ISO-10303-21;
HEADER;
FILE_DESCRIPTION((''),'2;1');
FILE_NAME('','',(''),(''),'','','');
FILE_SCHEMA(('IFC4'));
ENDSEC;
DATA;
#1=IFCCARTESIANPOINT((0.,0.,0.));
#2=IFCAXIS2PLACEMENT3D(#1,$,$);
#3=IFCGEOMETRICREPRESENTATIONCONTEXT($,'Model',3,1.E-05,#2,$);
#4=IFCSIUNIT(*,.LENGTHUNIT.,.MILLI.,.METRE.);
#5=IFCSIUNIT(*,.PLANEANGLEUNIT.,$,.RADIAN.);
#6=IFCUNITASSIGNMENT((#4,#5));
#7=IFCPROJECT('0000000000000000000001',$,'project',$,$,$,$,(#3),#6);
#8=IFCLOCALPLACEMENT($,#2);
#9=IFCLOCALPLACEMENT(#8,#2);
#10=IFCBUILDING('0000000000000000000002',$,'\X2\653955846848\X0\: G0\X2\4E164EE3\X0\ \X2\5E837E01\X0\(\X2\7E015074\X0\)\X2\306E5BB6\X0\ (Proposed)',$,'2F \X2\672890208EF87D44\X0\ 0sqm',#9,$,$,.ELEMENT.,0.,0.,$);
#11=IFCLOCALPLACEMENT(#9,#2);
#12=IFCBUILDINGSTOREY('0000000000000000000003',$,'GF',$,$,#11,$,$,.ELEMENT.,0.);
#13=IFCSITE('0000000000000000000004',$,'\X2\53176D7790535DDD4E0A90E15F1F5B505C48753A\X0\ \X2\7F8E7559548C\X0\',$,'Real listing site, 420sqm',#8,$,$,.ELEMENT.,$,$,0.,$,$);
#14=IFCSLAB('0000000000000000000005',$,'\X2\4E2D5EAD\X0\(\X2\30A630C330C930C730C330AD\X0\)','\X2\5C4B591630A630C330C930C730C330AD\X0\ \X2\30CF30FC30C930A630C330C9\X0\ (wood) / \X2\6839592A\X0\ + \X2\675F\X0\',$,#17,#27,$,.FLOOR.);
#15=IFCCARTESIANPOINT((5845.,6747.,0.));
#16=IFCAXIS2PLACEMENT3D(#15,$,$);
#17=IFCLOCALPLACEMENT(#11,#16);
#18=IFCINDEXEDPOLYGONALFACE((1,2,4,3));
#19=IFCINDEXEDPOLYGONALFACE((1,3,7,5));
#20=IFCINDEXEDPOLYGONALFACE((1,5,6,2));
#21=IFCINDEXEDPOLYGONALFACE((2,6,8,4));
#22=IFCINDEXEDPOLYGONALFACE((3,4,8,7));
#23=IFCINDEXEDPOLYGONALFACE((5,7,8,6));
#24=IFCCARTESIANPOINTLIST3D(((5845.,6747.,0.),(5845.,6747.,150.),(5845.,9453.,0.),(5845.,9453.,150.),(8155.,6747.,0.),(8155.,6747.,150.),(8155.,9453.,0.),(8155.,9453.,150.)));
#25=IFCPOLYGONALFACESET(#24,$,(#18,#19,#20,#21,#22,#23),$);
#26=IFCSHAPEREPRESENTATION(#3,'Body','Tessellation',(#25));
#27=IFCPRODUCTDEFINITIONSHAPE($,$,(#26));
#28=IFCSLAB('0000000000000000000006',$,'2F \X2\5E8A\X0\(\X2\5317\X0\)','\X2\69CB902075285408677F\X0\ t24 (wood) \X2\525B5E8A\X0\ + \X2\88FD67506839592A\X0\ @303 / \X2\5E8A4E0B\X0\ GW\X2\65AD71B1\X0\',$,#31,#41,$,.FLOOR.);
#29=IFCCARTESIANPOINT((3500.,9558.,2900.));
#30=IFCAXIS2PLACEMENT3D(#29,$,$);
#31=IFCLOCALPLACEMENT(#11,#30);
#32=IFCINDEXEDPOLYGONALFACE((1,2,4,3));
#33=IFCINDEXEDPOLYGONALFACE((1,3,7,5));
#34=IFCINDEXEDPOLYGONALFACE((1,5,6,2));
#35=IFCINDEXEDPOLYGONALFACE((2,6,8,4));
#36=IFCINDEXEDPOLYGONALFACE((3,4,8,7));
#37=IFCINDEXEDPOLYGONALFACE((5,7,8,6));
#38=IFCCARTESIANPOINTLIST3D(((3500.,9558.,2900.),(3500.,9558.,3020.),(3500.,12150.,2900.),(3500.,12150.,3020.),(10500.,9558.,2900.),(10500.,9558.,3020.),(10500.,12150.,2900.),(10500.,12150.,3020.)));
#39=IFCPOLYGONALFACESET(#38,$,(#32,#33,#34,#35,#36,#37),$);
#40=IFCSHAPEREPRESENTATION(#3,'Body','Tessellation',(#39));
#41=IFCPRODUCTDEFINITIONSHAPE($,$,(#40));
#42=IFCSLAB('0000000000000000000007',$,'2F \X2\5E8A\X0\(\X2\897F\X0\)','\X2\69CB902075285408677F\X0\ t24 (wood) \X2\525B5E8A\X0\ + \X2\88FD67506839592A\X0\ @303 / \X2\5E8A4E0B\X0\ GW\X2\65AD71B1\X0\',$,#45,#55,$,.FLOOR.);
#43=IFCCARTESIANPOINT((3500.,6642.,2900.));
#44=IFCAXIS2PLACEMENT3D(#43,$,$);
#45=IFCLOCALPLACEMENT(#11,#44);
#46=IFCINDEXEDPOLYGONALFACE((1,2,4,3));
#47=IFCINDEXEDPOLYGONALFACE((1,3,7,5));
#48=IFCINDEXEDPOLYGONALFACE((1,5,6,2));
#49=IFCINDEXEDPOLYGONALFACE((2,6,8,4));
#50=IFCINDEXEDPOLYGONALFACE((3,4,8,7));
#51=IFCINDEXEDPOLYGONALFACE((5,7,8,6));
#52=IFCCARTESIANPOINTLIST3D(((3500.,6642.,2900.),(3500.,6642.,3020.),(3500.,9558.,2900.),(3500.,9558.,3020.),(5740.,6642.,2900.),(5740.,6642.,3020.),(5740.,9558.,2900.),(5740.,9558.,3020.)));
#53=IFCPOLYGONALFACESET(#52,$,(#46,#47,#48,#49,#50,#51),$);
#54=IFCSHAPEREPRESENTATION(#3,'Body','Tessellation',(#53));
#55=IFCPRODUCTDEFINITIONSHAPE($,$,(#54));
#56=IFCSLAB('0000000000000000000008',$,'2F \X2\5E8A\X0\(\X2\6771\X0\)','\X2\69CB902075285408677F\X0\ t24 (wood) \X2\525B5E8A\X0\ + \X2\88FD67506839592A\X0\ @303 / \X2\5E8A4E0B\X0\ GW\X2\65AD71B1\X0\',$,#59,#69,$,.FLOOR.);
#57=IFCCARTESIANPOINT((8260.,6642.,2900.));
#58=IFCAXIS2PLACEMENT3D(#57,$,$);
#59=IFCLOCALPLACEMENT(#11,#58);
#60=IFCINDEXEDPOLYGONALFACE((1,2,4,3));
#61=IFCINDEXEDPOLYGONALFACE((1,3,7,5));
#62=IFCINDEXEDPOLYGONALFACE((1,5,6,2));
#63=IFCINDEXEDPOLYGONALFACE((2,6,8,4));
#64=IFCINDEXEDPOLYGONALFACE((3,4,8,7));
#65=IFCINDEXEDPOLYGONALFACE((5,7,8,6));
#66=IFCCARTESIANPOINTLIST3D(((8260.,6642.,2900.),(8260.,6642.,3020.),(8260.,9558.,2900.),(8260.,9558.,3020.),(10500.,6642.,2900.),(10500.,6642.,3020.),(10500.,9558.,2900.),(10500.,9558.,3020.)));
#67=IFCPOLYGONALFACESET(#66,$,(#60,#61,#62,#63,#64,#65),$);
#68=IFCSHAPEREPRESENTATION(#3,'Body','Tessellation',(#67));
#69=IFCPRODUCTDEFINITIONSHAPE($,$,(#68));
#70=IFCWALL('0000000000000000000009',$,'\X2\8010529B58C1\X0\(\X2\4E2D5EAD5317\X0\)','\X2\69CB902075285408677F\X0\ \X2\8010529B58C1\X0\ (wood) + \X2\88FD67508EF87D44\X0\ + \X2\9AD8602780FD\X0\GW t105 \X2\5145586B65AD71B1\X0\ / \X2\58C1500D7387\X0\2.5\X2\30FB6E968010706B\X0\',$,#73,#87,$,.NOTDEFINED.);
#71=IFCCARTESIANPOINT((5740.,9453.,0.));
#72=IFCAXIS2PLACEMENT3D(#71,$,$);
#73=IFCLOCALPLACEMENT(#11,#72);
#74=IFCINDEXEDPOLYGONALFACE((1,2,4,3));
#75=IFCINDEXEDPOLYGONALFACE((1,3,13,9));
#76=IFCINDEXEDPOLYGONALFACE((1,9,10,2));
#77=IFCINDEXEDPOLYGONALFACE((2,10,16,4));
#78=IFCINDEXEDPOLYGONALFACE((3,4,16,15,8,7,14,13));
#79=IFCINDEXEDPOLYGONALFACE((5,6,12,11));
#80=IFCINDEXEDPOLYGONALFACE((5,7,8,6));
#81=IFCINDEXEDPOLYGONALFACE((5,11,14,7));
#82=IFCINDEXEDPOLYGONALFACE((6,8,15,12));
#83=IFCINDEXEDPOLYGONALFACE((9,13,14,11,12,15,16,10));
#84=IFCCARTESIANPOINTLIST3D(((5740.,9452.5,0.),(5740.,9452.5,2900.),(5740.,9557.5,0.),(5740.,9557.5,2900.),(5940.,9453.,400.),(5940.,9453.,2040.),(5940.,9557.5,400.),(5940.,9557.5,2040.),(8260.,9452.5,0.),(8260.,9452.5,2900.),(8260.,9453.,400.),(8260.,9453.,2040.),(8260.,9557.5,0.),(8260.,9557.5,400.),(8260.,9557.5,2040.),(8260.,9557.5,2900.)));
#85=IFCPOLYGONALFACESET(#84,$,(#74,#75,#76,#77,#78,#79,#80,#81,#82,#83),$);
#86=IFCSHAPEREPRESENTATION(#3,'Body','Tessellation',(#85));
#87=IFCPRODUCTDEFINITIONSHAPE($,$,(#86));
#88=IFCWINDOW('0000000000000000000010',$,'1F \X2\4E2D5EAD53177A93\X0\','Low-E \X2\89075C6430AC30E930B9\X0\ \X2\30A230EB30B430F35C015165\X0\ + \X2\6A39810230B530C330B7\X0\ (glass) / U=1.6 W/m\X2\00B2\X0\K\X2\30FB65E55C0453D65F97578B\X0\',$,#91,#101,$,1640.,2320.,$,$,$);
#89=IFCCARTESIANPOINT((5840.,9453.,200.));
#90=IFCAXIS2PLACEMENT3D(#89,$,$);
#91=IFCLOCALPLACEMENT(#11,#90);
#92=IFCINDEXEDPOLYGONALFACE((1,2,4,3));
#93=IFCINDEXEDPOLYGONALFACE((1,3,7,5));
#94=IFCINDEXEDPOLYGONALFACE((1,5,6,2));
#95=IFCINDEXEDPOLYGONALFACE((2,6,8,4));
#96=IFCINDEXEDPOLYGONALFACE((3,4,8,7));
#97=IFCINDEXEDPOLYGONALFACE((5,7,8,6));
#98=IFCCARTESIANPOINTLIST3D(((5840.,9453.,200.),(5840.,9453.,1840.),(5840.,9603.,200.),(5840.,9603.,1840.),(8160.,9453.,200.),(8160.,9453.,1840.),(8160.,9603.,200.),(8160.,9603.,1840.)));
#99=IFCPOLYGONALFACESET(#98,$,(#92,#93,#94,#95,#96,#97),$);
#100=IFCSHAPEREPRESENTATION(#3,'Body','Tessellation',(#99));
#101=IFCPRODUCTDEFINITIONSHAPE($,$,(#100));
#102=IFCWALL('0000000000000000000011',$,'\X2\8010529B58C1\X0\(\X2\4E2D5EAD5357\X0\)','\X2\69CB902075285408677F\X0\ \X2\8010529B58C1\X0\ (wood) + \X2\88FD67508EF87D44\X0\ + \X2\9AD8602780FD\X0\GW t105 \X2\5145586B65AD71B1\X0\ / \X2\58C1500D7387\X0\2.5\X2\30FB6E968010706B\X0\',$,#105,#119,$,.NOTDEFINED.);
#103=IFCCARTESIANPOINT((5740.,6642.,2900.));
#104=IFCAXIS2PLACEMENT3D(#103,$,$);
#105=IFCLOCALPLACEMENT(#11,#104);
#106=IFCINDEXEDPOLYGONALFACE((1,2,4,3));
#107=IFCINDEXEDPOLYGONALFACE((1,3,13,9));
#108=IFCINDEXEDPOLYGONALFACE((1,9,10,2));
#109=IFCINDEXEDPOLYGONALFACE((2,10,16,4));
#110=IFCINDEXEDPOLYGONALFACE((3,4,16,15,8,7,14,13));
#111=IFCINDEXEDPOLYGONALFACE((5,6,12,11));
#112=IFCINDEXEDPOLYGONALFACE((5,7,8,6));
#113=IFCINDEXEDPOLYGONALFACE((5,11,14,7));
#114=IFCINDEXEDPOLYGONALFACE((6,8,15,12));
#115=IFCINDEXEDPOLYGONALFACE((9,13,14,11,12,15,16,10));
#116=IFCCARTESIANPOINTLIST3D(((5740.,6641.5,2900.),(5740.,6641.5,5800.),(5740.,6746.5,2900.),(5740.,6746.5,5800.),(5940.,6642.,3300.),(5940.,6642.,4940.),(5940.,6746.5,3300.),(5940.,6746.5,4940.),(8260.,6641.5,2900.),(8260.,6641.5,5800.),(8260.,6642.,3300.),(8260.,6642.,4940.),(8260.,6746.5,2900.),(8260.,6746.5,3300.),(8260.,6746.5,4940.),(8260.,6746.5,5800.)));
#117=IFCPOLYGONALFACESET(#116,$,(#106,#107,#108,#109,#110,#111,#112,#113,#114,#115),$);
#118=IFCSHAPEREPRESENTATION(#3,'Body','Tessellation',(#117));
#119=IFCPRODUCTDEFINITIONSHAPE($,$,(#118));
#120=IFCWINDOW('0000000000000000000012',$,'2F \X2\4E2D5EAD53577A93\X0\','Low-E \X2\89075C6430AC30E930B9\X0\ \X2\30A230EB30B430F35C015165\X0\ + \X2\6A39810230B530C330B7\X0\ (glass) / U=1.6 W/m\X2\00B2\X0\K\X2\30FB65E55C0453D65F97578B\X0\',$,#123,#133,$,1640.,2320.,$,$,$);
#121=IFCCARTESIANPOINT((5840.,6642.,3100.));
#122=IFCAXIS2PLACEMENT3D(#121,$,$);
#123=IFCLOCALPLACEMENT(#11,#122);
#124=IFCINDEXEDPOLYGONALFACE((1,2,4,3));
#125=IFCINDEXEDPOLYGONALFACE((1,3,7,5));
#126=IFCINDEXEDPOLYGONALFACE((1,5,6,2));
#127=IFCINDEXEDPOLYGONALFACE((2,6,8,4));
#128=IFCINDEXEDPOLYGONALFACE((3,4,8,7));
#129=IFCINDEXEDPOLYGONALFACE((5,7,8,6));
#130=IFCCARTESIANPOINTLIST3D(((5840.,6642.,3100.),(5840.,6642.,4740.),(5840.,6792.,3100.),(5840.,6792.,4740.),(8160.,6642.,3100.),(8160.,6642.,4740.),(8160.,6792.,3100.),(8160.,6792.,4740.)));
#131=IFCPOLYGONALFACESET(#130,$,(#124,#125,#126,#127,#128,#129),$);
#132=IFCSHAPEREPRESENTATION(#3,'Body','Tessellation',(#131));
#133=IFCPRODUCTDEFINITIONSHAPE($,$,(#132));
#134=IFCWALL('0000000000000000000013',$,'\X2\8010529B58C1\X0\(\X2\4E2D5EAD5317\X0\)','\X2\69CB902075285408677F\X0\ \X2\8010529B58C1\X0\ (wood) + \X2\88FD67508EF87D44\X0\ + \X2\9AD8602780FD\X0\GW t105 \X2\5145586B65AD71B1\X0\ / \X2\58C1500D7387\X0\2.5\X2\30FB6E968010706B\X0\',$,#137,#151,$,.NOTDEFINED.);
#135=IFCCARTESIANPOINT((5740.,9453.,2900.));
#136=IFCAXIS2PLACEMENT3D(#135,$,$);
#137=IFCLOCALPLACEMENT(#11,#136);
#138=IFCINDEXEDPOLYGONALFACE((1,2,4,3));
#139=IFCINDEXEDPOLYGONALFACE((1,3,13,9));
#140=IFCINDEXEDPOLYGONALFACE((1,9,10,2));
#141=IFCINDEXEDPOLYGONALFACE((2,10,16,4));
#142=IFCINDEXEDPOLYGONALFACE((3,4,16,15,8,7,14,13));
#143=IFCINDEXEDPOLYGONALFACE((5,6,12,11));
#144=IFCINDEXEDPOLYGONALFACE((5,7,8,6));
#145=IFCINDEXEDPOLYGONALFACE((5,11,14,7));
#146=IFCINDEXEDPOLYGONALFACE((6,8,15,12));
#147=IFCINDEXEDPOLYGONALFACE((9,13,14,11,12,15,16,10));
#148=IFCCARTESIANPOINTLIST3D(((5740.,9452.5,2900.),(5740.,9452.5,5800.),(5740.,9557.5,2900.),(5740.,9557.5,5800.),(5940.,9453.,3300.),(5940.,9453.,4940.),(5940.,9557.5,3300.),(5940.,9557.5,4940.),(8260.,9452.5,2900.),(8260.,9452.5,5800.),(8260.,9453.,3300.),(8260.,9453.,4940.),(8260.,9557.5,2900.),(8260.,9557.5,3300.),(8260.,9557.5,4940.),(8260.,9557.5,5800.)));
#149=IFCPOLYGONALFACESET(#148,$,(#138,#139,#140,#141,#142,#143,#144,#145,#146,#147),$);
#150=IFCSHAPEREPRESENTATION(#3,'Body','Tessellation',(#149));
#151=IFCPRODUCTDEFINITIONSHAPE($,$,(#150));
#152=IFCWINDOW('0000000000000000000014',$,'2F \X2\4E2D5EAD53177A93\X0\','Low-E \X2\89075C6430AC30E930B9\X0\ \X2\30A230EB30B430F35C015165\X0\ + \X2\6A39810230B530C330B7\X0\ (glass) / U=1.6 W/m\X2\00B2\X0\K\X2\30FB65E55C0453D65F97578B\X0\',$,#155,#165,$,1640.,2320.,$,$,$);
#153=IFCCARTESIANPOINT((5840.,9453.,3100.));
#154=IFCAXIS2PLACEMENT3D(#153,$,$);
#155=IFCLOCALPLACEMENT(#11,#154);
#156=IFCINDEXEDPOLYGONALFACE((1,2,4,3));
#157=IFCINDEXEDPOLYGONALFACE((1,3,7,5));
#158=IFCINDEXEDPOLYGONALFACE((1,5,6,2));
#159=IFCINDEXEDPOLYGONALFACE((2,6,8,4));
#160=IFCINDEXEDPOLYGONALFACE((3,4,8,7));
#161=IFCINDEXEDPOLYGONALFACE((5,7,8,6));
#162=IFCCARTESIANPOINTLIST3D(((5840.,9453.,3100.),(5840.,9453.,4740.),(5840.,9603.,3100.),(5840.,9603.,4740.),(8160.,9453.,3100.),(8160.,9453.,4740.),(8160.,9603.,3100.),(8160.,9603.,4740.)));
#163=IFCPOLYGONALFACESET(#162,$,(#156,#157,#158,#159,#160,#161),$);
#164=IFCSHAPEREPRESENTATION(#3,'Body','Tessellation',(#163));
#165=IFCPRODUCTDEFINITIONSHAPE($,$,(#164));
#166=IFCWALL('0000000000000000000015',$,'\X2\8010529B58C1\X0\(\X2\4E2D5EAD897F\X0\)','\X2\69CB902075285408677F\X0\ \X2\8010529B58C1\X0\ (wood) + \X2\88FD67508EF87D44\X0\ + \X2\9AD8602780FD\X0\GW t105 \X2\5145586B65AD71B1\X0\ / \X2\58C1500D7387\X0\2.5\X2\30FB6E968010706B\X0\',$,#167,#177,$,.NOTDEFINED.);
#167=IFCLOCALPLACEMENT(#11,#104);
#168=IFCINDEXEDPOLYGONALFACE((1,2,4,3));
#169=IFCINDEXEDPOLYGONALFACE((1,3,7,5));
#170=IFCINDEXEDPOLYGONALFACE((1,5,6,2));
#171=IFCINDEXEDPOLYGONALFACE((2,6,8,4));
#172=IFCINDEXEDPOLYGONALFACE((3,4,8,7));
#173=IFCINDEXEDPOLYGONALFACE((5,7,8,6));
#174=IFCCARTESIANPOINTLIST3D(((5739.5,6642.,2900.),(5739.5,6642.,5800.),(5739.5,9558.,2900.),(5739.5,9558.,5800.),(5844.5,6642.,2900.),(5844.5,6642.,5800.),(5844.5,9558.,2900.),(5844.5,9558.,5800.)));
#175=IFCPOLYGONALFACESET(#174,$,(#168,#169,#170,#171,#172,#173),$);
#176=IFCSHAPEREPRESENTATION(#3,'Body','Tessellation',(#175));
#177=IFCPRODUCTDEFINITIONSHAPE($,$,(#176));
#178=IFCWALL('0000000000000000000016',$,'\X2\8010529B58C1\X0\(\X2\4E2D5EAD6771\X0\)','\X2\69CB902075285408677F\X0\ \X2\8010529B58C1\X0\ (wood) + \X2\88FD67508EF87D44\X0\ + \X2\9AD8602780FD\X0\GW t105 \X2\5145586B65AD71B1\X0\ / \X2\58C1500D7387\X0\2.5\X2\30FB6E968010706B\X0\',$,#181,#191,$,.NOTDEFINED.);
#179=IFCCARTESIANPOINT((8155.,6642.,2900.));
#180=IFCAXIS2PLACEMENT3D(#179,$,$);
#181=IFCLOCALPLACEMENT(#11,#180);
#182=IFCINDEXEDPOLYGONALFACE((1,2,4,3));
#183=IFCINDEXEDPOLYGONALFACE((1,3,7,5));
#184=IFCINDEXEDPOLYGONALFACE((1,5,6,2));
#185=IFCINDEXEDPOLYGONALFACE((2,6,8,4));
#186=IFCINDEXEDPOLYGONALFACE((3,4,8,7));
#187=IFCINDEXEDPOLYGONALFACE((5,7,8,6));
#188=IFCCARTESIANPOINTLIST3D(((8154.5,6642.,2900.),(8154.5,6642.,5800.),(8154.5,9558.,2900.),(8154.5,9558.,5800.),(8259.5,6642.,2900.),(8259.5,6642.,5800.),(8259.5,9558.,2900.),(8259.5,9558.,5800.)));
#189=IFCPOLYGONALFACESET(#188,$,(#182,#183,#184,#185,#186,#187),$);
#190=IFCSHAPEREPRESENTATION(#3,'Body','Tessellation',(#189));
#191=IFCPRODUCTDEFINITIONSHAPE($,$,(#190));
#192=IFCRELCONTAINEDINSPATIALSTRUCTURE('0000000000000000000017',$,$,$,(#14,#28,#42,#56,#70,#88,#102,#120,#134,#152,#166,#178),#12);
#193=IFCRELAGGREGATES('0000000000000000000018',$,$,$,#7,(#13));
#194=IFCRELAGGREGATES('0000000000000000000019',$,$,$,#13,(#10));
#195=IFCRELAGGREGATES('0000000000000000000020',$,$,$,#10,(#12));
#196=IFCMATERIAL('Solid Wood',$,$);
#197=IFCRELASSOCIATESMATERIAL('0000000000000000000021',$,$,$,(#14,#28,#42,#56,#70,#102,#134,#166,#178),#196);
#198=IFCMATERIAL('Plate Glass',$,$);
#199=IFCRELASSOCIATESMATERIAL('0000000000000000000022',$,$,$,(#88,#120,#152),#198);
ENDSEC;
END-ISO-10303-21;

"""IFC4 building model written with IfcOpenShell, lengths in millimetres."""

from ifc_helpers import new_model, si_unit, frame, frame_2d, origin, place, context, project, spatial, rectangle, extrude, material, element, fill, save


model = new_model("IFC4")

# Units and contexts
model_context = context("Model", 3, precision=1e-05, world=origin())
ifc_project = project(units=[si_unit("LENGTHUNIT", "METRE", prefix="MILLI"), si_unit("PLANEANGLEUNIT", "RADIAN")], contexts=[model_context])

# Site, building, storey
site_placement = place(None, origin())
site = spatial("IfcSite", under=ifc_project, at=site_placement, Name="北海道川上郡弟子屈町 美留和", ObjectType="Real listing site, 420sqm", CompositionType="ELEMENT", RefElevation=0.0)
building_placement = place(site_placement, origin())
building = spatial("IfcBuilding", under=site, at=building_placement, Name="改善案: G0世代 広縁(縁側)の家 (Proposed)", ObjectType="2F 木造軸組 0sqm", CompositionType="ELEMENT", ElevationOfRefHeight=0.0, ElevationOfTerrain=0.0)
storey_placement = place(building_placement, origin())
storey = spatial("IfcBuildingStorey", under=building, at=storey_placement, Name="GF", CompositionType="ELEMENT", Elevation=0.0)

# Slabs
ifc_material_1 = material(Name="Solid Wood")
slab_1_placement = place(storey_placement, frame((5845.0, 6747.0, 0.0)))
element("IfcSlab", 1, at=slab_1_placement, inside=storey, material=ifc_material_1, Name="中庭(ウッドデッキ)", Description="屋外ウッドデッキ ハードウッド (wood) / 根太 + 束", PredefinedType="FLOOR", context=model_context, shape_type="SweptSolid", body=[
    extrude(rectangle(XDim=2310.0, YDim=2706.0, at=frame_2d((1155.0, 1353.0))), frame((5845.0, 6747.0, 0.0)), (0.0, 0.0, 1.0), 150.0),
])
slab_2_placement = place(storey_placement, frame((3500.0, 9558.0, 2900.0)))
element("IfcSlab", 2, at=slab_2_placement, inside=storey, material=ifc_material_1, Name="2F 床(北)", Description="構造用合板 t24 (wood) 剛床 + 製材根太 @303 / 床下 GW断熱", PredefinedType="FLOOR", context=model_context, shape_type="SweptSolid", body=[
    extrude(rectangle(XDim=7000.0, YDim=2592.0, at=frame_2d((3500.0, 1296.0))), frame((3500.0, 9558.0, 2900.0)), (0.0, 0.0, 1.0), 120.0),
])
slab_3_placement = place(storey_placement, frame((3500.0, 6642.0, 2900.0)))
element("IfcSlab", 3, at=slab_3_placement, inside=storey, material=ifc_material_1, Name="2F 床(西)", Description="構造用合板 t24 (wood) 剛床 + 製材根太 @303 / 床下 GW断熱", PredefinedType="FLOOR", context=model_context, shape_type="SweptSolid", body=[
    extrude(rectangle(XDim=2240.0, YDim=2916.0, at=frame_2d((1120.0, 1458.0))), frame((3500.0, 6642.0, 2900.0)), (0.0, 0.0, 1.0), 120.0),
])
slab_4_placement = place(storey_placement, frame((8260.0, 6642.0, 2900.0)))
element("IfcSlab", 4, at=slab_4_placement, inside=storey, material=ifc_material_1, Name="2F 床(東)", Description="構造用合板 t24 (wood) 剛床 + 製材根太 @303 / 床下 GW断熱", PredefinedType="FLOOR", context=model_context, shape_type="SweptSolid", body=[
    extrude(rectangle(XDim=2240.0, YDim=2916.0, at=frame_2d((1120.0, 1458.0))), frame((8260.0, 6642.0, 2900.0)), (0.0, 0.0, 1.0), 120.0),
])

# Wall, opening, window
wall_1_placement = place(storey_placement, frame((5740.0, 9453.0, 0.0)))
wall_1 = element("IfcWall", 5, at=wall_1_placement, inside=storey, material=ifc_material_1, Name="耐力壁(中庭北)", Description="構造用合板 耐力壁 (wood) + 製材軸組 + 高性能GW t105 充填断熱 / 壁倍率2.5・準耐火", PredefinedType="NOTDEFINED", context=model_context, shape_type="SweptSolid", body=[
    extrude(rectangle(XDim=2520.0, YDim=105.0, at=frame_2d((1260.0, 52.0))), frame((5740.0, 9453.0, 0.0)), (0.0, 0.0, 1.0), 2900.0),
])
opening_1_placement = place(storey_placement, frame((5840.0, 9453.0, 200.0)))
opening_1 = element("IfcOpeningElement", 6, at=opening_1_placement, cuts=wall_1, PredefinedType="NOTDEFINED", context=model_context, shape_type="SweptSolid", body=[
    extrude(rectangle(XDim=2320.0, YDim=150.0, at=frame_2d((1160.0, 75.0))), frame((5840.0, 9453.0, 200.0)), (0.0, 0.0, 1.0), 1640.0),
])
ifc_material_2 = material(Name="Plate Glass")
window_1_placement = place(storey_placement, frame((5840.0, 9453.0, 200.0)))
window_1 = element("IfcWindow", 7, at=window_1_placement, inside=storey, material=ifc_material_2, Name="1F 中庭北窓", Description="Low-E 複層ガラス アルゴン封入 + 樹脂サッシ (glass) / U=1.6 W/m²K・日射取得型", OverallHeight=1640.0, OverallWidth=2320.0, context=model_context, shape_type="SweptSolid", body=[
    extrude(rectangle(XDim=2320.0, YDim=150.0, at=frame_2d((1160.0, 75.0))), frame((5840.0, 9453.0, 200.0)), (0.0, 0.0, 1.0), 1640.0),
])
fill(opening_1, window_1)

# Walls, openings, windows
wall_2_placement = place(storey_placement, frame((5740.0, 6642.0, 2900.0)))
wall_2 = element("IfcWall", 8, at=wall_2_placement, inside=storey, material=ifc_material_1, Name="耐力壁(中庭南)", Description="構造用合板 耐力壁 (wood) + 製材軸組 + 高性能GW t105 充填断熱 / 壁倍率2.5・準耐火", PredefinedType="NOTDEFINED", context=model_context, shape_type="SweptSolid", body=[
    extrude(rectangle(XDim=2520.0, YDim=105.0, at=frame_2d((1260.0, 52.0))), frame((5740.0, 6642.0, 2900.0)), (0.0, 0.0, 1.0), 2900.0),
])
opening_2_placement = place(storey_placement, frame((5840.0, 6642.0, 3100.0)))
opening_2 = element("IfcOpeningElement", 9, at=opening_2_placement, cuts=wall_2, PredefinedType="NOTDEFINED", context=model_context, shape_type="SweptSolid", body=[
    extrude(rectangle(XDim=2320.0, YDim=150.0, at=frame_2d((1160.0, 75.0))), frame((5840.0, 6642.0, 3100.0)), (0.0, 0.0, 1.0), 1640.0),
])
window_2_placement = place(storey_placement, frame((5840.0, 6642.0, 3100.0)))
window_2 = element("IfcWindow", 10, at=window_2_placement, inside=storey, material=ifc_material_2, Name="2F 中庭南窓", Description="Low-E 複層ガラス アルゴン封入 + 樹脂サッシ (glass) / U=1.6 W/m²K・日射取得型", OverallHeight=1640.0, OverallWidth=2320.0, context=model_context, shape_type="SweptSolid", body=[
    extrude(rectangle(XDim=2320.0, YDim=150.0, at=frame_2d((1160.0, 75.0))), frame((5840.0, 6642.0, 3100.0)), (0.0, 0.0, 1.0), 1640.0),
])
fill(opening_2, window_2)
wall_3_placement = place(storey_placement, frame((5740.0, 9453.0, 2900.0)))
wall_3 = element("IfcWall", 11, at=wall_3_placement, inside=storey, material=ifc_material_1, Name="耐力壁(中庭北)", Description="構造用合板 耐力壁 (wood) + 製材軸組 + 高性能GW t105 充填断熱 / 壁倍率2.5・準耐火", PredefinedType="NOTDEFINED", context=model_context, shape_type="SweptSolid", body=[
    extrude(rectangle(XDim=2520.0, YDim=105.0, at=frame_2d((1260.0, 52.0))), frame((5740.0, 9453.0, 2900.0)), (0.0, 0.0, 1.0), 2900.0),
])
opening_3_placement = place(storey_placement, frame((5840.0, 9453.0, 3100.0)))
opening_3 = element("IfcOpeningElement", 12, at=opening_3_placement, cuts=wall_3, PredefinedType="NOTDEFINED", context=model_context, shape_type="SweptSolid", body=[
    extrude(rectangle(XDim=2320.0, YDim=150.0, at=frame_2d((1160.0, 75.0))), frame((5840.0, 9453.0, 3100.0)), (0.0, 0.0, 1.0), 1640.0),
])
window_3_placement = place(storey_placement, frame((5840.0, 9453.0, 3100.0)))
window_3 = element("IfcWindow", 13, at=window_3_placement, inside=storey, material=ifc_material_2, Name="2F 中庭北窓", Description="Low-E 複層ガラス アルゴン封入 + 樹脂サッシ (glass) / U=1.6 W/m²K・日射取得型", OverallHeight=1640.0, OverallWidth=2320.0, context=model_context, shape_type="SweptSolid", body=[
    extrude(rectangle(XDim=2320.0, YDim=150.0, at=frame_2d((1160.0, 75.0))), frame((5840.0, 9453.0, 3100.0)), (0.0, 0.0, 1.0), 1640.0),
])
fill(opening_3, window_3)

# Walls
wall_4_placement = place(storey_placement, frame((5740.0, 6642.0, 2900.0)))
element("IfcWall", 14, at=wall_4_placement, inside=storey, material=ifc_material_1, Name="耐力壁(中庭西)", Description="構造用合板 耐力壁 (wood) + 製材軸組 + 高性能GW t105 充填断熱 / 壁倍率2.5・準耐火", PredefinedType="NOTDEFINED", context=model_context, shape_type="SweptSolid", body=[
    extrude(rectangle(XDim=105.0, YDim=2916.0, at=frame_2d((52.0, 1458.0))), frame((5740.0, 6642.0, 2900.0)), (0.0, 0.0, 1.0), 2900.0),
])
wall_5_placement = place(storey_placement, frame((8155.0, 6642.0, 2900.0)))
element("IfcWall", 15, at=wall_5_placement, inside=storey, material=ifc_material_1, Name="耐力壁(中庭東)", Description="構造用合板 耐力壁 (wood) + 製材軸組 + 高性能GW t105 充填断熱 / 壁倍率2.5・準耐火", PredefinedType="NOTDEFINED", context=model_context, shape_type="SweptSolid", body=[
    extrude(rectangle(XDim=105.0, YDim=2916.0, at=frame_2d((52.0, 1458.0))), frame((8155.0, 6642.0, 2900.0)), (0.0, 0.0, 1.0), 2900.0),
])

save(model, "model.ifc")
